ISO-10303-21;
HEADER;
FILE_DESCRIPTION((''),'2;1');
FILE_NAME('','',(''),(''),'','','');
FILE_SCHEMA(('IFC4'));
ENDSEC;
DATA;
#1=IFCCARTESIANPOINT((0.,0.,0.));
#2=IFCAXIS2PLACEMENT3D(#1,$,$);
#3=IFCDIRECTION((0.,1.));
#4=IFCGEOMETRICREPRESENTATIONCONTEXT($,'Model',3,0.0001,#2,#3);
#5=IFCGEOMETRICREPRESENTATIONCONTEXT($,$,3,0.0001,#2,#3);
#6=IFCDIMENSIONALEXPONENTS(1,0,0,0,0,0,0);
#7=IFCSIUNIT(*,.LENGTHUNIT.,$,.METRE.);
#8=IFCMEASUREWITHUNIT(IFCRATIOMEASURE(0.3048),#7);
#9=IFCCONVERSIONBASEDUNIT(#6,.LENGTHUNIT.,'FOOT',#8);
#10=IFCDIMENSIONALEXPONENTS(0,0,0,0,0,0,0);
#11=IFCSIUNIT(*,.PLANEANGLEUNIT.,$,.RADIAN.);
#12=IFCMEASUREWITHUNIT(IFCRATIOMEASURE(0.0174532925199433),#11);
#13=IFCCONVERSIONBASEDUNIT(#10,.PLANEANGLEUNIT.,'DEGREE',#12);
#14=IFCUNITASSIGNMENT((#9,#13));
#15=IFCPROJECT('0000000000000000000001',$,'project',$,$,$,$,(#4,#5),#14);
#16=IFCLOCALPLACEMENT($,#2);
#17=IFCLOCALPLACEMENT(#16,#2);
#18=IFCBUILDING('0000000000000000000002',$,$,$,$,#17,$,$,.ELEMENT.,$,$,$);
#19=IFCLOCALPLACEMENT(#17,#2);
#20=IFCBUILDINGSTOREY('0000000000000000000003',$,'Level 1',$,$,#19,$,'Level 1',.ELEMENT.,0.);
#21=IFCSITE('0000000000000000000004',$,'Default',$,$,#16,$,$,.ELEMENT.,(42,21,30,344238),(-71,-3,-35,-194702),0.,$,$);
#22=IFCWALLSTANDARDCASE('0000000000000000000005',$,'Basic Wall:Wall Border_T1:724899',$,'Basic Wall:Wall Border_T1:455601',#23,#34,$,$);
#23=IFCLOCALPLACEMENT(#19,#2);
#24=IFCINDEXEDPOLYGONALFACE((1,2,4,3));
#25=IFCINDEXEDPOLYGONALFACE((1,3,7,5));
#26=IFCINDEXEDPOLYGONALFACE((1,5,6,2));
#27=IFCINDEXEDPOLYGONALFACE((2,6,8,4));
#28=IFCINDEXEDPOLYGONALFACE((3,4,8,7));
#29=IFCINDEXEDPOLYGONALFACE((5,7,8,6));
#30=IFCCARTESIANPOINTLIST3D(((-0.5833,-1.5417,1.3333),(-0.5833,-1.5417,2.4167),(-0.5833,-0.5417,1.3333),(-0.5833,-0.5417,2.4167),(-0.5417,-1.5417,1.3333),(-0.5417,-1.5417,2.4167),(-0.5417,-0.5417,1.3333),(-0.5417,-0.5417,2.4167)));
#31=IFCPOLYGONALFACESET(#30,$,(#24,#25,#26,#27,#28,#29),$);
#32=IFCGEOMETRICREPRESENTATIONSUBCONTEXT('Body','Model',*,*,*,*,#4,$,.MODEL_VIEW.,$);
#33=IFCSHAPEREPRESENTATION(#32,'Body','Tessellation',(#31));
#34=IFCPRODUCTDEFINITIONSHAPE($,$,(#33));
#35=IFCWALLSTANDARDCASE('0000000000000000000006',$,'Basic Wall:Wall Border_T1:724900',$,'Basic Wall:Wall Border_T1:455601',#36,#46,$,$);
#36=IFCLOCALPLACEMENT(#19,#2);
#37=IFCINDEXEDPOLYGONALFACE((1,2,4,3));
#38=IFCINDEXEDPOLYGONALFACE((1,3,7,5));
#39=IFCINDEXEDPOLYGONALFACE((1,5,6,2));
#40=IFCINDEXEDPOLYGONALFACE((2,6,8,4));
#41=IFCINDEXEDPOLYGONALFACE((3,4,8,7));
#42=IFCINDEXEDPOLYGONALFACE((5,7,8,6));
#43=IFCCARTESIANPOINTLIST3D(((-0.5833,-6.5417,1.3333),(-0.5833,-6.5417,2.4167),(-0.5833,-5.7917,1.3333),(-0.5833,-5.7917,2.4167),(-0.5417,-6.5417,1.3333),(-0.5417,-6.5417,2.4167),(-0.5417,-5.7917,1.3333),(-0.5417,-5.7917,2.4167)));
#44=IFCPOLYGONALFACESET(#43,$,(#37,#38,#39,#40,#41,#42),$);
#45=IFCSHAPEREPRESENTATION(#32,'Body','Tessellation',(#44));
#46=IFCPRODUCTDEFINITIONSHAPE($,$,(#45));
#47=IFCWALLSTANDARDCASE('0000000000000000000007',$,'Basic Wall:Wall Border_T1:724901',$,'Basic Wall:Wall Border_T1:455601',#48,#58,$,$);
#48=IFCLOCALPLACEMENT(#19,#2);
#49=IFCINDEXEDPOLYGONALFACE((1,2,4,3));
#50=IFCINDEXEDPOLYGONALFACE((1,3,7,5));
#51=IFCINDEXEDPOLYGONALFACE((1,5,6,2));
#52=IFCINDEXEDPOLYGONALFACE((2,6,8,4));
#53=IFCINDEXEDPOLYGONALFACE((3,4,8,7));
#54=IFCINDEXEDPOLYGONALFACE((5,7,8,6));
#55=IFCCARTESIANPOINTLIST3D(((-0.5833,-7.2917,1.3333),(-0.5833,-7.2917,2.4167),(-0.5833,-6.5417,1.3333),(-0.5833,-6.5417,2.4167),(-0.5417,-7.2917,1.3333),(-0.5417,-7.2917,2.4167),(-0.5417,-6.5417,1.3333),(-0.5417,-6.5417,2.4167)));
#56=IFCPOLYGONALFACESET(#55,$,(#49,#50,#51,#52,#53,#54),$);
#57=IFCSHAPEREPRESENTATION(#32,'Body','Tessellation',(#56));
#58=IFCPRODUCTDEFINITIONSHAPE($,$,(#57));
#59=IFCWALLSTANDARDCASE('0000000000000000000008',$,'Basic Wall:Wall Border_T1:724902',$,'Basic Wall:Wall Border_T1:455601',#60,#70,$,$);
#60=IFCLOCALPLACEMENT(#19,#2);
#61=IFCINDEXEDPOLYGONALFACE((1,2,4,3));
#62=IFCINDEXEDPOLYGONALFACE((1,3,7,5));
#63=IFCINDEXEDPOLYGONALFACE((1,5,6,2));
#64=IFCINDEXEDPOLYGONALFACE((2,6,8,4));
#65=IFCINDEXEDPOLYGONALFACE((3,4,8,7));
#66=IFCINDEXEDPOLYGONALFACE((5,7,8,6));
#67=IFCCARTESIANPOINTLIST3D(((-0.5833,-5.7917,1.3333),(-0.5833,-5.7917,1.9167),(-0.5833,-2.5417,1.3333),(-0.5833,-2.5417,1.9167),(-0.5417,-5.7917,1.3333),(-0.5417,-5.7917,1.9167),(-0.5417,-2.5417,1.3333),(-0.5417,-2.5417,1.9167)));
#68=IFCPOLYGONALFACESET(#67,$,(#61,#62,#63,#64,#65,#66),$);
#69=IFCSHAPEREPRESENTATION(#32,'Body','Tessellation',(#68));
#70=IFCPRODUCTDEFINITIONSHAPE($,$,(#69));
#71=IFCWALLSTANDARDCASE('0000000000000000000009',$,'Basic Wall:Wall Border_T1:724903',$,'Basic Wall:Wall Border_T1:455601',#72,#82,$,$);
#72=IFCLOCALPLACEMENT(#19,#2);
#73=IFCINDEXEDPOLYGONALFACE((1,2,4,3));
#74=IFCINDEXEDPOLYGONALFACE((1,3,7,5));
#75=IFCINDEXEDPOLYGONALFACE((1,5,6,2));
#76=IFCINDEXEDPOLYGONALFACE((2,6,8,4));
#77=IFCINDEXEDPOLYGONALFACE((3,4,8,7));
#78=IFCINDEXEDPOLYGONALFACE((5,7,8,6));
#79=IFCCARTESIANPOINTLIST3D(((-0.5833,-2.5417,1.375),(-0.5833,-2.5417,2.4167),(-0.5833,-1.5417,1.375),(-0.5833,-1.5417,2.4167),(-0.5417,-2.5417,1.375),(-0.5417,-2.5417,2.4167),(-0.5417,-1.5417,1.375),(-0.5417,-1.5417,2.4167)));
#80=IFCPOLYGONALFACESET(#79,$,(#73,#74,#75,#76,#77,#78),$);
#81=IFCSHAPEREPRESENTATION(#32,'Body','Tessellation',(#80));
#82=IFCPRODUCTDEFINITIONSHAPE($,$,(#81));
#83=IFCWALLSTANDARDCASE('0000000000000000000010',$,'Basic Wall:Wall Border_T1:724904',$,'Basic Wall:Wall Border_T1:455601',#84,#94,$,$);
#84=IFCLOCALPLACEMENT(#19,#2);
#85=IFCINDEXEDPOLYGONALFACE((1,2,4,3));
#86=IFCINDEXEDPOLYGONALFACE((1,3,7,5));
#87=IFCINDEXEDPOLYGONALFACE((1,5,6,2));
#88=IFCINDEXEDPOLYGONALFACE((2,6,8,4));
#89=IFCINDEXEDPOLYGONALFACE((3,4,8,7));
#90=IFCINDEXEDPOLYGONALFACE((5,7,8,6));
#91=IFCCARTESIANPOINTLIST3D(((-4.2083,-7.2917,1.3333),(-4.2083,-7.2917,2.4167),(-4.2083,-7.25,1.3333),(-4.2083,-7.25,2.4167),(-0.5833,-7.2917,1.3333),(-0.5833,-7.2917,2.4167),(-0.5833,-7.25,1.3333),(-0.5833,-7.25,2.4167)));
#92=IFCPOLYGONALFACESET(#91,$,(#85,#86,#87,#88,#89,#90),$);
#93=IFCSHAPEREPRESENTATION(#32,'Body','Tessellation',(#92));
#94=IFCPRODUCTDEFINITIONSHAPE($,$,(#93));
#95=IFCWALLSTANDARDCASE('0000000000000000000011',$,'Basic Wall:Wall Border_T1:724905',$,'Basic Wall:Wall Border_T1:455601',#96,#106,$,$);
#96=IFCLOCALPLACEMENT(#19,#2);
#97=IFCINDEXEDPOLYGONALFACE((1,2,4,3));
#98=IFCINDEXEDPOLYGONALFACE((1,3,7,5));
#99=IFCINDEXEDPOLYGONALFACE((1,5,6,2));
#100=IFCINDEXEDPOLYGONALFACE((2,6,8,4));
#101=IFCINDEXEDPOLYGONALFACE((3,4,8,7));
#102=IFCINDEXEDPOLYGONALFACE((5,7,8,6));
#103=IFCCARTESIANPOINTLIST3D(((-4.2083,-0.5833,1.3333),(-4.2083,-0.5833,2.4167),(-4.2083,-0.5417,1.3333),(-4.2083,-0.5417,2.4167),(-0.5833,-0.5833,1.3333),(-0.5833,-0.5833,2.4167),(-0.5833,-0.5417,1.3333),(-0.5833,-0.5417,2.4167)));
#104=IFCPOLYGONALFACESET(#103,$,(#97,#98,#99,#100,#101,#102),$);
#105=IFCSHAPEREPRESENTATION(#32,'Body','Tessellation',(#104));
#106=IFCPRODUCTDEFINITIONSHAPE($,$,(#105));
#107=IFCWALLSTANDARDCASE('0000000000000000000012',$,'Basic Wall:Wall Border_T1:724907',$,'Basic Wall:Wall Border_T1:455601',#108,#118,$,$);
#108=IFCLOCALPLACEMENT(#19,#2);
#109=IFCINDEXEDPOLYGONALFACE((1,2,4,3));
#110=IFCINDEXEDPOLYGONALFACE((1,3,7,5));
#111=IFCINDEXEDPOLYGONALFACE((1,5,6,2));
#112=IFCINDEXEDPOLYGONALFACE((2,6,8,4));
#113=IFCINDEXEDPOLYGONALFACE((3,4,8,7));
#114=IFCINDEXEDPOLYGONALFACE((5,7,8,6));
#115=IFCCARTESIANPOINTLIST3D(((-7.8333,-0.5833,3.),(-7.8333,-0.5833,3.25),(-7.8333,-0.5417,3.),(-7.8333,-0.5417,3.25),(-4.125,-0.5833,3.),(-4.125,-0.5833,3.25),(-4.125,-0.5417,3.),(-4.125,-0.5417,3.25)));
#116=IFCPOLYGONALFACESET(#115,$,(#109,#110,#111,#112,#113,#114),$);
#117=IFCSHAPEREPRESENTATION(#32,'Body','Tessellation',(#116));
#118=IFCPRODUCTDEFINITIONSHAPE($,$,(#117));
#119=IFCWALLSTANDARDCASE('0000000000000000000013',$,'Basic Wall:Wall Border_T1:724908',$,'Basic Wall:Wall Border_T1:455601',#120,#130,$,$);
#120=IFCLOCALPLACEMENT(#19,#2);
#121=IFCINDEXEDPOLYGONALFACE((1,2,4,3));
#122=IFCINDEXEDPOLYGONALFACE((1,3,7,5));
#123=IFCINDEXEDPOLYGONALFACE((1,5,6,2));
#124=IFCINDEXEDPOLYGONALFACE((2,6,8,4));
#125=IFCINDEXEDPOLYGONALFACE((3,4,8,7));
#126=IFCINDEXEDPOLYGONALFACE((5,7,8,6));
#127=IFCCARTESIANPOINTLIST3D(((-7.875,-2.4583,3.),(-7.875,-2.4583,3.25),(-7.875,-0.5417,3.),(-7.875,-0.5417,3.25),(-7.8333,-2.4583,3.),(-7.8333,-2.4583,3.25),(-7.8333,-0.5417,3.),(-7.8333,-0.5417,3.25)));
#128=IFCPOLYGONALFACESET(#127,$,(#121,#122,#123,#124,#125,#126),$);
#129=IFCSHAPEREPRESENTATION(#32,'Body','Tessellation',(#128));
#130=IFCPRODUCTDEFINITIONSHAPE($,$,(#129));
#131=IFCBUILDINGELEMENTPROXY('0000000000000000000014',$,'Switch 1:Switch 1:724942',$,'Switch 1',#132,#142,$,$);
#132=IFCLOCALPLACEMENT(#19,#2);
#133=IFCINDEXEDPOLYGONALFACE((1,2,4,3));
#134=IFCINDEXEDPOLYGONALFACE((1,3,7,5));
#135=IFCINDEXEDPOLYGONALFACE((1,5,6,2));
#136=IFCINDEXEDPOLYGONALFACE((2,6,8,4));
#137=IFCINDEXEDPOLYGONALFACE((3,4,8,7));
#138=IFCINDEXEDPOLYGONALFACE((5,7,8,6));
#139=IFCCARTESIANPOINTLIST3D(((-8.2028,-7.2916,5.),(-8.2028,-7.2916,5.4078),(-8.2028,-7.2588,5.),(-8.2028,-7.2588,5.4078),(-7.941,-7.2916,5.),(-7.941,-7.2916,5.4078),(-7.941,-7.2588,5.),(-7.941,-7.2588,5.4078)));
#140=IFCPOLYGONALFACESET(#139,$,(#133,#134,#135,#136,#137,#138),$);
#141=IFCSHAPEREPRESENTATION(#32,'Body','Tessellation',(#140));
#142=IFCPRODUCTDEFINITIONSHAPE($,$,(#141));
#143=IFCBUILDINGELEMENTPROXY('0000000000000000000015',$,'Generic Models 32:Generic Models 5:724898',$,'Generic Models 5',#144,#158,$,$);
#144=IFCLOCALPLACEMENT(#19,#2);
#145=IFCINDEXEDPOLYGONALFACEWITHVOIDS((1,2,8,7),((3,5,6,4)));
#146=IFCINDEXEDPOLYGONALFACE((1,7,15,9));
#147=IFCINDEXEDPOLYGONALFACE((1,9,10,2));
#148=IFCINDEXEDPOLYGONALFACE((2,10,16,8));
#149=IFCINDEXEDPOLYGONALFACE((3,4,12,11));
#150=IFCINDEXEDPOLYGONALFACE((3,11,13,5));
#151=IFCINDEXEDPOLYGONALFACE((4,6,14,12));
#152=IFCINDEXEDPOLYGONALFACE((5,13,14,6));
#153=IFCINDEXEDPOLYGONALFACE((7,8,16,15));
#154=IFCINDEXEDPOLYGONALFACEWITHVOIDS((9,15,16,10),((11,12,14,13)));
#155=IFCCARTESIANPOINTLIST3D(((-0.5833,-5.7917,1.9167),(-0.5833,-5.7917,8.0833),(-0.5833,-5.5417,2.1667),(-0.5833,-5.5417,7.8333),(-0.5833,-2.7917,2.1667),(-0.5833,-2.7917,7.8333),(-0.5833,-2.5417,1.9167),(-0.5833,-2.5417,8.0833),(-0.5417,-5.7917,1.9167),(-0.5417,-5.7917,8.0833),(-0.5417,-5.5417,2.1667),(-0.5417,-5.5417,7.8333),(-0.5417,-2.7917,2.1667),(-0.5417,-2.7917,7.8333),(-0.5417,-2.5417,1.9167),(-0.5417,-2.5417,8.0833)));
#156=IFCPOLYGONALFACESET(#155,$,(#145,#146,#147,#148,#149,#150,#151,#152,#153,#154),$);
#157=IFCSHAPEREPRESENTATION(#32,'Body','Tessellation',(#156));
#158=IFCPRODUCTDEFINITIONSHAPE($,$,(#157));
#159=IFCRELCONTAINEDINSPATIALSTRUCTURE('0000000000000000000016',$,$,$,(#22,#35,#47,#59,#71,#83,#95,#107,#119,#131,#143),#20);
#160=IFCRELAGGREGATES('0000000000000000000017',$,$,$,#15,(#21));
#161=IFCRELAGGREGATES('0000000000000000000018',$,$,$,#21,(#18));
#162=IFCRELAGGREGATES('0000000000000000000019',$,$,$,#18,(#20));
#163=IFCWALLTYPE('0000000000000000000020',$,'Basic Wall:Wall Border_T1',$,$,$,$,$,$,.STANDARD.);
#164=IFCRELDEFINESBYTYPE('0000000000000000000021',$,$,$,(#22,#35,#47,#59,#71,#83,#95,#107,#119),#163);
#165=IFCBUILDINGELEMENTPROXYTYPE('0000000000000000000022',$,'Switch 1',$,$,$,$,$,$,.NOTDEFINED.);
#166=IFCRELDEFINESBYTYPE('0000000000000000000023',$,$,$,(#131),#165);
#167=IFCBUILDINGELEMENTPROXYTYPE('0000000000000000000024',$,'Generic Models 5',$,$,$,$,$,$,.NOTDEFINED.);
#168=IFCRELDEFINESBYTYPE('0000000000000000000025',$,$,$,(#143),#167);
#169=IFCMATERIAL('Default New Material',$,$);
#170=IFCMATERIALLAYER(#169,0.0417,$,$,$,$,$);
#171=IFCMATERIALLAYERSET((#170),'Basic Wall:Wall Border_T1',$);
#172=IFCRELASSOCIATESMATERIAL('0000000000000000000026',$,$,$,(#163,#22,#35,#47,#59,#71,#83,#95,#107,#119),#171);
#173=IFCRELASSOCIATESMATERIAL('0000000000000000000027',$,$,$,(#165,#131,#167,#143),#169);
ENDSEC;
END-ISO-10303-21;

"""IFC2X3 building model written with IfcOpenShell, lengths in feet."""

from ifc_helpers import new_model, entity, si_unit, converted_unit, direction, frame, frame_2d, origin, origin_2d_with_axis, place, context, subcontext, project, spatial, polyline, rectangle, outline, extrude, clip, bounded_halfspace, source, transform, mapped, material, layer, layer_set, layer_usage, type_object, type_shapes, element, save


model = new_model("IFC2X3")

# Units and contexts
model_context = context("Model", 3, precision=0.0001, world=origin(), true_north=direction((0.0, 1.0)))
context_of_model = context(None, 3, precision=0.0001, world=origin(), true_north=direction((0.0, 1.0)))
body_context = subcontext(model_context, "Body", "Model", "MODEL_VIEW")
ifc_project = project(units=[converted_unit("LENGTHUNIT", "FOOT", entity("IfcRatioMeasure", 0.3048), si_unit("LENGTHUNIT", "METRE"), dimensions=[1, 0, 0, 0, 0, 0, 0]), converted_unit("PLANEANGLEUNIT", "DEGREE", entity("IfcRatioMeasure", 0.0174532925199433), si_unit("PLANEANGLEUNIT", "RADIAN"), dimensions=[0, 0, 0, 0, 0, 0, 0])], contexts=[model_context, context_of_model])

# Site, building, storey
site_placement = place(None, origin())
site = spatial("IfcSite", under=ifc_project, at=site_placement, Name="Default", CompositionType="ELEMENT", RefLatitude=(42, 21, 30, 344238), RefLongitude=(-71, -3, -35, -194702), RefElevation=0.0)
building_placement = place(site_placement, origin())
building = spatial("IfcBuilding", under=site, at=building_placement, CompositionType="ELEMENT")
storey_placement = place(building_placement, origin())
storey = spatial("IfcBuildingStorey", under=building, at=storey_placement, Name="Level 1", LongName="Level 1", CompositionType="ELEMENT", Elevation=0.0)

# Walls
ifc_material = material(Name="Default New Material")
ifc_layer = layer(ifc_material, 0.0417)
ifc_layer_set = layer_set([ifc_layer], Name="Basic Wall:Wall Border_T1")
ifc_layer_usage_1 = layer_usage(ifc_layer_set, "AXIS2", "POSITIVE", -0.0208)
wall_type = type_object("IfcWallType", Name="Basic Wall:Wall Border_T1", PredefinedType="STANDARD", material=ifc_layer_set)
wall_1_placement = place(storey_placement, frame((-0.5625, -0.5417, 1.3333), z_axis=(0.0, 0.0, 1.0), x_axis=(0.0, -1.0, 0.0)))
element("IfcWallStandardCase", 1, at=wall_1_placement, inside=storey, type_object=wall_type, material=ifc_layer_usage_1, Name="Basic Wall:Wall Border_T1:724899", ObjectType="Basic Wall:Wall Border_T1:455601", context=body_context, shape_type="SweptSolid", body=[
    extrude(rectangle(XDim=1.0, YDim=0.0417, at=frame_2d((0.5, 0.0), x_axis=(-1.0, 0.0))), origin(), (0.0, 0.0, 1.0), 1.0833),
])
ifc_layer_usage_2 = layer_usage(ifc_layer_set, "AXIS2", "POSITIVE", -0.0208)
wall_2_placement = place(storey_placement, frame((-0.5625, -5.7917, 1.3333), z_axis=(0.0, 0.0, 1.0), x_axis=(0.0, -1.0, 0.0)))
element("IfcWallStandardCase", 2, at=wall_2_placement, inside=storey, type_object=wall_type, material=ifc_layer_usage_2, Name="Basic Wall:Wall Border_T1:724900", ObjectType="Basic Wall:Wall Border_T1:455601", context=body_context, shape_type="SweptSolid", body=[
    extrude(rectangle(XDim=0.75, YDim=0.0417, at=frame_2d((0.375, 0.0), x_axis=(-1.0, 0.0))), origin(), (0.0, 0.0, 1.0), 1.0833),
])
ifc_layer_usage_3 = layer_usage(ifc_layer_set, "AXIS2", "POSITIVE", -0.0208)
wall_3_placement = place(storey_placement, frame((-0.5625, -6.5417, 1.3333), z_axis=(0.0, 0.0, 1.0), x_axis=(0.0, -1.0, 0.0)))
element("IfcWallStandardCase", 3, at=wall_3_placement, inside=storey, type_object=wall_type, material=ifc_layer_usage_3, Name="Basic Wall:Wall Border_T1:724901", ObjectType="Basic Wall:Wall Border_T1:455601", context=body_context, shape_type="SweptSolid", body=[
    extrude(rectangle(XDim=0.75, YDim=0.0417, at=frame_2d((0.375, 0.0), x_axis=(-1.0, 0.0))), origin(), (0.0, 0.0, 1.0), 1.0833),
])
ifc_layer_usage_4 = layer_usage(ifc_layer_set, "AXIS2", "POSITIVE", -0.0208)
wall_4_placement = place(storey_placement, frame((-0.5625, -2.5417, 1.3333), z_axis=(0.0, 0.0, 1.0), x_axis=(0.0, -1.0, 0.0)))
element("IfcWallStandardCase", 4, at=wall_4_placement, inside=storey, type_object=wall_type, material=ifc_layer_usage_4, Name="Basic Wall:Wall Border_T1:724902", ObjectType="Basic Wall:Wall Border_T1:455601", context=body_context, shape_type="SweptSolid", body=[
    extrude(rectangle(XDim=3.25, YDim=0.0417, at=frame_2d((1.625, 0.0), x_axis=(-1.0, 0.0))), origin(), (0.0, 0.0, 1.0), 0.5833),
])
ifc_layer_usage_5 = layer_usage(ifc_layer_set, "AXIS2", "POSITIVE", -0.0208)
wall_5_placement = place(storey_placement, frame((-0.5625, -1.5417, 1.375), z_axis=(0.0, 0.0, 1.0), x_axis=(0.0, -1.0, 0.0)))
element("IfcWallStandardCase", 5, at=wall_5_placement, inside=storey, type_object=wall_type, material=ifc_layer_usage_5, Name="Basic Wall:Wall Border_T1:724903", ObjectType="Basic Wall:Wall Border_T1:455601", context=body_context, shape_type="SweptSolid", body=[
    extrude(rectangle(XDim=1.0, YDim=0.0417, at=frame_2d((0.5, 0.0), x_axis=(-1.0, 0.0))), origin(), (0.0, 0.0, 1.0), 1.0417),
])
ifc_layer_usage_6 = layer_usage(ifc_layer_set, "AXIS2", "POSITIVE", -0.0208)
wall_6_placement = place(storey_placement, frame((-0.5833, -7.2708, 1.3333), z_axis=(0.0, 0.0, 1.0), x_axis=(-1.0, 0.0, 0.0)))
element("IfcWallStandardCase", 6, at=wall_6_placement, inside=storey, type_object=wall_type, material=ifc_layer_usage_6, Name="Basic Wall:Wall Border_T1:724904", ObjectType="Basic Wall:Wall Border_T1:455601", context=body_context, shape_type="SweptSolid", body=[
    extrude(rectangle(XDim=3.625, YDim=0.0417, at=frame_2d((1.8125, 0.0), x_axis=(-1.0, 0.0))), origin(), (0.0, 0.0, 1.0), 1.0833),
])
ifc_layer_usage_7 = layer_usage(ifc_layer_set, "AXIS2", "POSITIVE", -0.0208)
wall_7_placement = place(storey_placement, frame((-4.2083, -0.5625, 1.3333)))
element("IfcWallStandardCase", 7, at=wall_7_placement, inside=storey, type_object=wall_type, material=ifc_layer_usage_7, Name="Basic Wall:Wall Border_T1:724905", ObjectType="Basic Wall:Wall Border_T1:455601", context=body_context, shape_type="Clipping", body=[
    clip(extrude(rectangle(XDim=3.625, YDim=0.0417, at=frame_2d((1.8125, 0.0), x_axis=(-1.0, 0.0))), origin(), (0.0, 0.0, 1.0), 1.0833), bounded_halfspace(frame((3.625, -0.0208, 1.0833), z_axis=(-1.0, 0.0, 0.0), x_axis=(0.0, -1.0, 0.0)), True, frame((3.625, -0.0208, 1.0833), z_axis=(-1.0, 0.0, 0.0), x_axis=(0.0, -1.0, 0.0)), polyline([(0.0, 0.0), (-0.0417, 0.0), (-0.0417, -1.0833), (0.0, -1.0833), (0.0, 0.0)]))),
])
ifc_layer_usage_8 = layer_usage(ifc_layer_set, "AXIS2", "POSITIVE", -0.0208)
wall_8_placement = place(storey_placement, frame((-7.8333, -0.5625, 3.0)))
element("IfcWallStandardCase", 8, at=wall_8_placement, inside=storey, type_object=wall_type, material=ifc_layer_usage_8, Name="Basic Wall:Wall Border_T1:724907", ObjectType="Basic Wall:Wall Border_T1:455601", context=body_context, shape_type="Clipping", body=[
    clip(extrude(rectangle(XDim=3.7083, YDim=0.0417, at=frame_2d((1.8542, 0.0), x_axis=(-1.0, 0.0))), origin(), (0.0, 0.0, 1.0), 0.25), bounded_halfspace(frame((0.0, -0.0208, 0.0), z_axis=(1.0, 0.0, 0.0), x_axis=(0.0, 1.0, 0.0)), True, frame((0.0, -0.0208, 0.0), z_axis=(1.0, 0.0, 0.0), x_axis=(0.0, 1.0, 0.0)), polyline([(0.0, 0.0), (0.0417, 0.0), (0.0417, 0.25), (0.0, 0.25), (0.0, 0.0)]))),
])
ifc_layer_usage_9 = layer_usage(ifc_layer_set, "AXIS2", "POSITIVE", -0.0208)
wall_9_placement = place(storey_placement, frame((-7.8542, -2.4583, 3.0), z_axis=(0.0, 0.0, 1.0), x_axis=(0.0, 1.0, 0.0)))
element("IfcWallStandardCase", 9, at=wall_9_placement, inside=storey, type_object=wall_type, material=ifc_layer_usage_9, Name="Basic Wall:Wall Border_T1:724908", ObjectType="Basic Wall:Wall Border_T1:455601", context=body_context, shape_type="SweptSolid", body=[
    extrude(rectangle(XDim=1.9167, YDim=0.0417, at=frame_2d((0.9583, 0.0), x_axis=(-1.0, 0.0))), origin(), (0.0, 0.0, 1.0), 0.25),
])

# Building element proxies
building_element_proxy_type_1 = type_object("IfcBuildingElementProxyType", Name="Switch 1", PredefinedType="NOTDEFINED", material=ifc_material)
shared_shape_1 = source(origin(), body_context, "Body", "SweptSolid", [
    extrude(rectangle(XDim=0.0328, YDim=0.2617, at=origin_2d_with_axis()), frame((0.0, -0.0164, 0.0), z_axis=(0.0, 0.0, 1.0), x_axis=(0.0, 1.0, 0.0)), (0.0, 0.0, 1.0), 0.4078),
])
type_shapes(building_element_proxy_type_1, [shared_shape_1])
proxy_1_placement = place(storey_placement, frame((-8.0719, -7.2588, 5.0)))
element("IfcBuildingElementProxy", 10, at=proxy_1_placement, inside=storey, type_object=building_element_proxy_type_1, material=ifc_material, Name="Switch 1:Switch 1:724942", ObjectType="Switch 1", context=body_context, shape_type="MappedRepresentation", body=[
    mapped(shared_shape_1, transform((0.0, 0.0, 0.0), scale=1.0)),
])
building_element_proxy_type_2 = type_object("IfcBuildingElementProxyType", Name="Generic Models 5", PredefinedType="NOTDEFINED", material=ifc_material)
shared_shape_2 = source(origin(), body_context, "Body", "SweptSolid", [
    extrude(outline(polyline([(-1.625, -3.0833), (1.625, -3.0833), (1.625, 3.0833), (-1.625, 3.0833), (-1.625, -3.0833)]), holes=[polyline([(1.375, 2.8333), (1.375, -2.8333), (-1.375, -2.8333), (-1.375, 2.8333), (1.375, 2.8333)])]), frame((0.0, 1.625, 3.0833), z_axis=(1.0, 0.0, 0.0), x_axis=(0.0, -1.0, 0.0)), (0.0, 0.0, 1.0), 0.0417),
])
type_shapes(building_element_proxy_type_2, [shared_shape_2])
proxy_2_placement = place(storey_placement, frame((-0.5833, -5.7917, 1.9167)))
element("IfcBuildingElementProxy", 11, at=proxy_2_placement, inside=storey, type_object=building_element_proxy_type_2, material=ifc_material, Name="Generic Models 32:Generic Models 5:724898", ObjectType="Generic Models 5", context=body_context, shape_type="MappedRepresentation", body=[
    mapped(shared_shape_2, transform((0.0, 0.0, 0.0), scale=1.0)),
])

save(model, "model.ifc")
